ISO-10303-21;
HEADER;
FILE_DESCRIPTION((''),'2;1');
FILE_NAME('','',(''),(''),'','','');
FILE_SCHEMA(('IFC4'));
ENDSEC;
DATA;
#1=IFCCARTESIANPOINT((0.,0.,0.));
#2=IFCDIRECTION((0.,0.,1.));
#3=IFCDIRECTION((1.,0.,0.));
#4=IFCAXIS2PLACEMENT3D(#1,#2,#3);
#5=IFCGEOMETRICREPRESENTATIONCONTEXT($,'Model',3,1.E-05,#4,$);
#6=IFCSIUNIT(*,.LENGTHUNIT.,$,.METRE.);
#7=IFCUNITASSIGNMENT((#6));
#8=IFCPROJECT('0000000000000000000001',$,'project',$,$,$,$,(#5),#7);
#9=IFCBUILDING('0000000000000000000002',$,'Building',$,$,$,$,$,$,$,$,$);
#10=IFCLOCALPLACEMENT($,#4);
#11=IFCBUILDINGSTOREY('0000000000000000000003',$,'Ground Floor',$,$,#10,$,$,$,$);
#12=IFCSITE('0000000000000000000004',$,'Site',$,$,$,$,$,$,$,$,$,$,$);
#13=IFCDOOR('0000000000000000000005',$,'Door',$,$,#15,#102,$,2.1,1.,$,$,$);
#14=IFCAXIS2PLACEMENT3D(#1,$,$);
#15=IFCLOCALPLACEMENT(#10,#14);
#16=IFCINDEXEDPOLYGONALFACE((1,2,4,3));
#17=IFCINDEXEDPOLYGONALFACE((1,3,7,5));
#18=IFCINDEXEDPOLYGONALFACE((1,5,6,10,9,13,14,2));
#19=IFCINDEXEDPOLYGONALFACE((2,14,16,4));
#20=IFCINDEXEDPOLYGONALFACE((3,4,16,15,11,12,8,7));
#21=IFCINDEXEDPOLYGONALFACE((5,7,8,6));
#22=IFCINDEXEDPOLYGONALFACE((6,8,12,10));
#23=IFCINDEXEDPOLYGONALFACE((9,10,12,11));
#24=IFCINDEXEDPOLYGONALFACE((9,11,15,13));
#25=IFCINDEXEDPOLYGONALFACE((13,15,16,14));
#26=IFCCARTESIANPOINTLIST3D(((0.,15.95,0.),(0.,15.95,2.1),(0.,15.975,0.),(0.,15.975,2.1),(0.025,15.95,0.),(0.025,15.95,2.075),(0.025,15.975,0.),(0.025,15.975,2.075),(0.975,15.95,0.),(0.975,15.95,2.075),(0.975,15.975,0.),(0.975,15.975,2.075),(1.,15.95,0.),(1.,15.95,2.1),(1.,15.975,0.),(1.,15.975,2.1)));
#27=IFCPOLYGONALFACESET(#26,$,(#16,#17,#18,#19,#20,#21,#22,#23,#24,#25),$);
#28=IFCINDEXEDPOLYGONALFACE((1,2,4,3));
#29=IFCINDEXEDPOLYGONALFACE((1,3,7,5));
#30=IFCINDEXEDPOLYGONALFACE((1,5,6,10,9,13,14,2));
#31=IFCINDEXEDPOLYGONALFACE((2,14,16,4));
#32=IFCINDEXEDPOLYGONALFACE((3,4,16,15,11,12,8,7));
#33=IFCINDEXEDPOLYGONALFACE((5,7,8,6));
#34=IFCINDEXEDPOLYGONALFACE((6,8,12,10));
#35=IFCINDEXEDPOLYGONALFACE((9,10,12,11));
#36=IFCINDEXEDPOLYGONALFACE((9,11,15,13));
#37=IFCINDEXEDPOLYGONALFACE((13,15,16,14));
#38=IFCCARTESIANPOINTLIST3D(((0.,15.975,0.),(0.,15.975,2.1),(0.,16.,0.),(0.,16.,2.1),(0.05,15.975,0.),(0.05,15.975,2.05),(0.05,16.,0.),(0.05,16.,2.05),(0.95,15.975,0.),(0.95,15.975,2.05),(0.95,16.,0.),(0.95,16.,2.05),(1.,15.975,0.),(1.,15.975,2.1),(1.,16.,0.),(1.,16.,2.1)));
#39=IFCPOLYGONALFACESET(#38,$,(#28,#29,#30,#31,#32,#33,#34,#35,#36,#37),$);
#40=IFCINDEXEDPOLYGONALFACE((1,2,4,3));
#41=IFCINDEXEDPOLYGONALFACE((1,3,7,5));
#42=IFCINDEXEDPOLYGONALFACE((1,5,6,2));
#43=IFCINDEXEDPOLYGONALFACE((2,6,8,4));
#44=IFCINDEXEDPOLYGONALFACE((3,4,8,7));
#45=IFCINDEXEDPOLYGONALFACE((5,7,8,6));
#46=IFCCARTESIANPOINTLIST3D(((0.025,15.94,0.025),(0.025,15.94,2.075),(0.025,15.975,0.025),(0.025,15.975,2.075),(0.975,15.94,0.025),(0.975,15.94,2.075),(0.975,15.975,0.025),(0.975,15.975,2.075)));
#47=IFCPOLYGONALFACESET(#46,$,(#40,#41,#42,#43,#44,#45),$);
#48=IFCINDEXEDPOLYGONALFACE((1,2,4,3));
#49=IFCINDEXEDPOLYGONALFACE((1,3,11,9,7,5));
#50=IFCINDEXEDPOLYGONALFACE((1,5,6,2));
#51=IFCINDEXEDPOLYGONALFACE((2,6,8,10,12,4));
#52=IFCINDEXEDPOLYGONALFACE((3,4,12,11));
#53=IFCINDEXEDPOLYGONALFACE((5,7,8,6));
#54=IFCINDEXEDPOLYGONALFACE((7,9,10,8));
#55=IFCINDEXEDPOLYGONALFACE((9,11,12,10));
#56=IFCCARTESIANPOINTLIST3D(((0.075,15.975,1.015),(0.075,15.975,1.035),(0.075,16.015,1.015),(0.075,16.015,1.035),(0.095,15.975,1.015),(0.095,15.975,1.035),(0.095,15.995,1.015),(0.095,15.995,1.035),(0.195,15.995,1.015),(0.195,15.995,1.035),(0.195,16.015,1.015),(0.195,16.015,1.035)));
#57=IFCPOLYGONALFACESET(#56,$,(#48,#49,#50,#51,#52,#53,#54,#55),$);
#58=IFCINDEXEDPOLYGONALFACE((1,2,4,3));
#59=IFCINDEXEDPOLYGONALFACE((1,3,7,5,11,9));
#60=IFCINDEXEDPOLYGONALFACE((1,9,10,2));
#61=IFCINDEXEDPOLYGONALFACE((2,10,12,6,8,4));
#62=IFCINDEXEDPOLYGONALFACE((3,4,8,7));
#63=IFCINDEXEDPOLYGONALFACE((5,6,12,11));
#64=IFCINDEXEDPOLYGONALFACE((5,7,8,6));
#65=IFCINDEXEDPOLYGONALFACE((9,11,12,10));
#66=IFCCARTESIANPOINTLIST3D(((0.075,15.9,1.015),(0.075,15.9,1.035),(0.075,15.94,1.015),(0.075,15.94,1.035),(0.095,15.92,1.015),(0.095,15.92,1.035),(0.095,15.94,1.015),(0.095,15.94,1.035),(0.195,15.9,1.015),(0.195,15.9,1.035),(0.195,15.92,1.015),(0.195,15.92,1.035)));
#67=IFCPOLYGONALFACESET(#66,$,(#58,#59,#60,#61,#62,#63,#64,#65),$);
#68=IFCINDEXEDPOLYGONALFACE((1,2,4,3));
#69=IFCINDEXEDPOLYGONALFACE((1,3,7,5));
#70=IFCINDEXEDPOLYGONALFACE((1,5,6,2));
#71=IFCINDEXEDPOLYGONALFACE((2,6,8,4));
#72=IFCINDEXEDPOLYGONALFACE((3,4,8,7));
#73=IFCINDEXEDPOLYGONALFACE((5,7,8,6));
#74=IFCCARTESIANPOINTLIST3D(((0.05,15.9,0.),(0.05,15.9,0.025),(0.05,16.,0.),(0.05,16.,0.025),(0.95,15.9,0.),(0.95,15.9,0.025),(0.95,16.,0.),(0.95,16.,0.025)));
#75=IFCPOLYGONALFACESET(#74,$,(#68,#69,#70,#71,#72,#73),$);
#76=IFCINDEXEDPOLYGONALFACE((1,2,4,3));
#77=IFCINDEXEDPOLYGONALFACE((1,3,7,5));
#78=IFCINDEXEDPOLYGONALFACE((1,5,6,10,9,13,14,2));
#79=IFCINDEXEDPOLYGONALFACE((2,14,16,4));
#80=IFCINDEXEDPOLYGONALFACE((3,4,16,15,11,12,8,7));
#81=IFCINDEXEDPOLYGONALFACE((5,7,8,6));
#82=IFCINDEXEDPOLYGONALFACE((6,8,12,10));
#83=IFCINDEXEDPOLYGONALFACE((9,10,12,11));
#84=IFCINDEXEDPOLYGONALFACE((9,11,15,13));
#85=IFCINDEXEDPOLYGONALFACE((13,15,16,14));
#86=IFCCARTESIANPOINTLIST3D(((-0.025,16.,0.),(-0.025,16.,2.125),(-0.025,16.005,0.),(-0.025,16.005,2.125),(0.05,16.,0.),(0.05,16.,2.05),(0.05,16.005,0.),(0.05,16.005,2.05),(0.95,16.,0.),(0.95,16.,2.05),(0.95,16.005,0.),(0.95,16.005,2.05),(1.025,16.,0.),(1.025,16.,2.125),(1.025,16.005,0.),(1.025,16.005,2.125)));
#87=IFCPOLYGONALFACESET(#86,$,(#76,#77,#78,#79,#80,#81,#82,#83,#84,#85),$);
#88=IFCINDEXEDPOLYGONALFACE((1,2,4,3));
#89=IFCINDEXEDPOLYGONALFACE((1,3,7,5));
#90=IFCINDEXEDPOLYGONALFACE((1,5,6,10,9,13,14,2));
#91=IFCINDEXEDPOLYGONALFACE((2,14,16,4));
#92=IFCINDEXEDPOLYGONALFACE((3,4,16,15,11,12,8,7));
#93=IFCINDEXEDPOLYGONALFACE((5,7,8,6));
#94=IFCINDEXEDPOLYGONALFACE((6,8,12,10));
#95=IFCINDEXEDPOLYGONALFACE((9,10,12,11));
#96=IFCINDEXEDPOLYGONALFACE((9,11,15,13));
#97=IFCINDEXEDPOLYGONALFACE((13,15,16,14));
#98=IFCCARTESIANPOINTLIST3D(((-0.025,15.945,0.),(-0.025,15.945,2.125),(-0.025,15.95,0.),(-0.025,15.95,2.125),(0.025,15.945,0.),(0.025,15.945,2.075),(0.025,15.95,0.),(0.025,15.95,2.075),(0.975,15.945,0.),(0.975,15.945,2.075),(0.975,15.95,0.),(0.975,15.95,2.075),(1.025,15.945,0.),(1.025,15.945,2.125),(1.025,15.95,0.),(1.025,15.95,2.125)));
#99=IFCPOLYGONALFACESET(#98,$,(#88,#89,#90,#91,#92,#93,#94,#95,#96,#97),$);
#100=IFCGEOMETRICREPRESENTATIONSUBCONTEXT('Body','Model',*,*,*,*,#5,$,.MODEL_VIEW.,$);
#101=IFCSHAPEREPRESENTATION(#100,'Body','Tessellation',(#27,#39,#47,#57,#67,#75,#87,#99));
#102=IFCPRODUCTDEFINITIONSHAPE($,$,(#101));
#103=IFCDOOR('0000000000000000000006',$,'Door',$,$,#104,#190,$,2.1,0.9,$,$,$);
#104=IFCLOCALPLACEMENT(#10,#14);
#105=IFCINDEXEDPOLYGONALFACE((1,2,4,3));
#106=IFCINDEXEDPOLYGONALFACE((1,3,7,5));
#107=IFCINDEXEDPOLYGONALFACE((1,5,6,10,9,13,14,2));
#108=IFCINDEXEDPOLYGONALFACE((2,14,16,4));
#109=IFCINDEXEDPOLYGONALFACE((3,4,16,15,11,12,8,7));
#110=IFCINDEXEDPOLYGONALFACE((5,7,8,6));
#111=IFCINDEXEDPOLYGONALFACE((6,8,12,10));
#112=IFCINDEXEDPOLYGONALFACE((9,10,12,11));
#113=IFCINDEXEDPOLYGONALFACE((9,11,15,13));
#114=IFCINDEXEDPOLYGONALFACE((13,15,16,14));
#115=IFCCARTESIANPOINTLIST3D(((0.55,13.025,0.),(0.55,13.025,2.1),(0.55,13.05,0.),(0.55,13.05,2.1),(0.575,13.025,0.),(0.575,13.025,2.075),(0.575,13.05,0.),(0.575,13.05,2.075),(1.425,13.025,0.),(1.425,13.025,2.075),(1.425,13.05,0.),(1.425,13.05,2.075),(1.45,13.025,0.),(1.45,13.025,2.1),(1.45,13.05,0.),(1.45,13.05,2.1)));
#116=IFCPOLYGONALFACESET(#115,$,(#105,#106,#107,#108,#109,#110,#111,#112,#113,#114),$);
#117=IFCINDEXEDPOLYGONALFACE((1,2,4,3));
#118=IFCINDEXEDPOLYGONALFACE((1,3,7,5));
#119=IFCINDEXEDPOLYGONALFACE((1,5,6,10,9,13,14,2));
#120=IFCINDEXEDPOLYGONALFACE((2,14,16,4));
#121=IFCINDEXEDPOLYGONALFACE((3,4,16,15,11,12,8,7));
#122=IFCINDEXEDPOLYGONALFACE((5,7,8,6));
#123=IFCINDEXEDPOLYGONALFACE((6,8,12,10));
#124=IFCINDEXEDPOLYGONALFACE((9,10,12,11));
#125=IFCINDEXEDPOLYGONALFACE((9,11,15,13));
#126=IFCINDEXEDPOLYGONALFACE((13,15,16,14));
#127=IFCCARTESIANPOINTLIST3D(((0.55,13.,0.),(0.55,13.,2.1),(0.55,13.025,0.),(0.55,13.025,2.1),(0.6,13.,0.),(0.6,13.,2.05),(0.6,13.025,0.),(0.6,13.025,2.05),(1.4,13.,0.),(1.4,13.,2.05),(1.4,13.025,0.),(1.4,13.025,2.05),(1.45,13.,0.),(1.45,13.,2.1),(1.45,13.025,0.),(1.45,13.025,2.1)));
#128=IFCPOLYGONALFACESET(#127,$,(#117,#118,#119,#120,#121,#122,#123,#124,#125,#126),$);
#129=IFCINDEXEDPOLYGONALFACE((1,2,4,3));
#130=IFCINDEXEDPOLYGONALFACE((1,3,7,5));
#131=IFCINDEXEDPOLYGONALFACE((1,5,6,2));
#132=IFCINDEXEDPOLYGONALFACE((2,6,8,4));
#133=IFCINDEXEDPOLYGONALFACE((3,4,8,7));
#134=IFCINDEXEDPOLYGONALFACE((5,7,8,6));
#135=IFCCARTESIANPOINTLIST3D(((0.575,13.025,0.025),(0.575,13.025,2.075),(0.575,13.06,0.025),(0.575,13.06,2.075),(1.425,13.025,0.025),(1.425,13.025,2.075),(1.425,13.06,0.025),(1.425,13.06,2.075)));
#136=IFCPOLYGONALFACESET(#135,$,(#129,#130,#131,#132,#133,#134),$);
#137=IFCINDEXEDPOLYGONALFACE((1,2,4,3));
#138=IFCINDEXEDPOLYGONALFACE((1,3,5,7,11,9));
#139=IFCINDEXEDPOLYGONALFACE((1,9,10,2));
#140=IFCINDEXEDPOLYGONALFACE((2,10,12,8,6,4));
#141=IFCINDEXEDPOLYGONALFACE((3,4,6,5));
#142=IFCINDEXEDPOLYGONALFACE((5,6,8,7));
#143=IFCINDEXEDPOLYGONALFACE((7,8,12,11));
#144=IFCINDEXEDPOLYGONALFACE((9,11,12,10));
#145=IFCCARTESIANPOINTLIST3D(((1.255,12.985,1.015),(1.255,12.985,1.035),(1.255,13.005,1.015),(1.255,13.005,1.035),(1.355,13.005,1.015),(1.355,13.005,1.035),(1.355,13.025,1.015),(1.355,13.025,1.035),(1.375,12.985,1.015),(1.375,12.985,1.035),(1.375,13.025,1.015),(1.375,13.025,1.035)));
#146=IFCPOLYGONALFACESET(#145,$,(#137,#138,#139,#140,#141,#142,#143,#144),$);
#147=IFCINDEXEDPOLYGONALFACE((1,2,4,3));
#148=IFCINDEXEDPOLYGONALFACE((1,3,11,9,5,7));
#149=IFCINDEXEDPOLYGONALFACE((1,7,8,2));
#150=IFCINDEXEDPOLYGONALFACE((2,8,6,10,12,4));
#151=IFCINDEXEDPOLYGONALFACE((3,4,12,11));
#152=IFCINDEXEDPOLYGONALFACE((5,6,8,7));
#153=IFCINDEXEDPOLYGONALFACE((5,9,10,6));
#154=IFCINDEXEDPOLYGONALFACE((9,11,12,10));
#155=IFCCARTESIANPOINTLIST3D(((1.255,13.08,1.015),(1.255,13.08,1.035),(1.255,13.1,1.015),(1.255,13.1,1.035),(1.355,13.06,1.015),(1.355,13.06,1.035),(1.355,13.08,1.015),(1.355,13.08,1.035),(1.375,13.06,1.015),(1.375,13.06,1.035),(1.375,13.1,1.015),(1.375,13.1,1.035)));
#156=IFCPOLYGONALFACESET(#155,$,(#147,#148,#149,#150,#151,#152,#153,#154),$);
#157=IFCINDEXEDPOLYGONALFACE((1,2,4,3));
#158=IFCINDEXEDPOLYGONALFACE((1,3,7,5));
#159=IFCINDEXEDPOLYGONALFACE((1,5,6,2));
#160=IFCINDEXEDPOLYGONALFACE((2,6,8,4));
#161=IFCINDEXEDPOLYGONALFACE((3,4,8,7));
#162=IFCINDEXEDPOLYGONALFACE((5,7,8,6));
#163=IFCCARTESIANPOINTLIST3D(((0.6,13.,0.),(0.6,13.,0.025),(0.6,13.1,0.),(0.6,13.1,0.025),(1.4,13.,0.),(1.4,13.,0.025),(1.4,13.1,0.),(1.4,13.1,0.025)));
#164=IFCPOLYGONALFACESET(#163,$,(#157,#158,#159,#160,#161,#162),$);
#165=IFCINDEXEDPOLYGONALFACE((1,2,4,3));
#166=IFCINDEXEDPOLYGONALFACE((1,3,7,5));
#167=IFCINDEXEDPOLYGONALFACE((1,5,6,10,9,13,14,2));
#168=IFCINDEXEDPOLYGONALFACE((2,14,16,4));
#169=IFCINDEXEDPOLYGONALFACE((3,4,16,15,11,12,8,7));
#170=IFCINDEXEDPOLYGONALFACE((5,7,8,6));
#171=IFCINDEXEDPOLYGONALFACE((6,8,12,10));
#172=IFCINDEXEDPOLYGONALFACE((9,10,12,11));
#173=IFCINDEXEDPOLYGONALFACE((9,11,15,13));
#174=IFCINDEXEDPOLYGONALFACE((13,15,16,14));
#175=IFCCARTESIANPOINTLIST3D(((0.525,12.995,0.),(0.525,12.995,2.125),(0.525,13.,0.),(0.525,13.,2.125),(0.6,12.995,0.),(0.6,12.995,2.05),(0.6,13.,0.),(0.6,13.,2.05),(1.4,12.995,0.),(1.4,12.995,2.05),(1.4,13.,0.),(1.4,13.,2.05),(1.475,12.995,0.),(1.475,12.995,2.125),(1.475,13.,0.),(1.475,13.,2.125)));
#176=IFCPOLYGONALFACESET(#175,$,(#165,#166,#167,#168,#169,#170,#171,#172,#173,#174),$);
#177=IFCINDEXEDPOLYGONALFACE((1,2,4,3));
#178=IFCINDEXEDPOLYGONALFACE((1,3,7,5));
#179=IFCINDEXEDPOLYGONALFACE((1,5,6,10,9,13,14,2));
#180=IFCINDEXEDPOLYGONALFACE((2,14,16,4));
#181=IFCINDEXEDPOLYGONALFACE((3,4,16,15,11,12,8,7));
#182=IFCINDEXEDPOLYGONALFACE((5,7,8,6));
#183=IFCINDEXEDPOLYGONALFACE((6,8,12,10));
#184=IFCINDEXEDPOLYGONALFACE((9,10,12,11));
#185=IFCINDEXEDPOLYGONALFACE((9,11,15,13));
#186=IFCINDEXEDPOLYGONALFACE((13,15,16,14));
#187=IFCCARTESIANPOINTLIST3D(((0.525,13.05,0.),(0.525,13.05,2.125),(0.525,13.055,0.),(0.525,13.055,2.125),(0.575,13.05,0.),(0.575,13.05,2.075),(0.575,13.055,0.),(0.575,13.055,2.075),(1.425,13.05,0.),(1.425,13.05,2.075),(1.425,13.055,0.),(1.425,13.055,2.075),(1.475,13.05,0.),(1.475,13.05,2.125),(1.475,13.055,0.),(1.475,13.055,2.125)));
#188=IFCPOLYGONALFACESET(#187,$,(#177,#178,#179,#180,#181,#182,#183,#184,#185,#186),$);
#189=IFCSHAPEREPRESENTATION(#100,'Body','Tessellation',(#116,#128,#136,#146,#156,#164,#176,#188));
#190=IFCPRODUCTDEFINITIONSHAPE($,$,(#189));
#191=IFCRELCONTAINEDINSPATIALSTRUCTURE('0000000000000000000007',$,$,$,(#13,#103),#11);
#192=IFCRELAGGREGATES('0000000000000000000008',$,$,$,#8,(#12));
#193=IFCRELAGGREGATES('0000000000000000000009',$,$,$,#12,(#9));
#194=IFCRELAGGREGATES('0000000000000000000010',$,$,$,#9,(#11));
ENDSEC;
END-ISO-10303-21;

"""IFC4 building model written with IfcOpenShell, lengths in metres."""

from ifc_helpers import new_model, si_unit, frame, origin_with_axes, place, context, subcontext, project, spatial, line, indexed_curve, outline, extrude, element, save


model = new_model("IFC4")

# Units and contexts
model_context = context("Model", 3, precision=1e-05, world=origin_with_axes())
body_context = subcontext(model_context, "Body", "Model", "MODEL_VIEW")
ifc_project = project(units=[si_unit("LENGTHUNIT", "METRE")], contexts=[model_context])

# Site, building, storey
site = spatial("IfcSite", under=ifc_project, Name="Site")
building = spatial("IfcBuilding", under=site, Name="Building")
storey_placement = place(None, origin_with_axes())
storey = spatial("IfcBuildingStorey", under=building, at=storey_placement, Name="Ground Floor")

# Doors
door_1_placement = place(storey_placement, frame((1.0, 16.0, 0.0), z_axis=(0.0, 0.0, 1.0), x_axis=(-1.0, 0.0, 0.0)))
element("IfcDoor", 1, at=door_1_placement, inside=storey, Name="Door", OverallHeight=2.1, OverallWidth=1.0, context=body_context, shape_type="SweptSolid", body=[
    extrude(outline(indexed_curve([(0.0, 0.0), (0.0, 2.1), (1.0, 2.1), (1.0, 0.0), (0.975, 0.0), (0.975, 2.075), (0.025, 2.075), (0.025, 0.0)], segments=[line(1, 2, 3, 4, 5, 6, 7, 8, 1)])), frame((0.0, 0.025, 0.0), z_axis=(0.0, -1.0, 0.0), x_axis=(1.0, 0.0, 0.0)), (0.0, 0.0, -1.0), 0.025),
    extrude(outline(indexed_curve([(0.0, 0.0), (0.0, 2.1), (1.0, 2.1), (1.0, 0.0), (0.95, 0.0), (0.95, 2.05), (0.05, 2.05), (0.05, 0.0)], segments=[line(1, 2, 3, 4, 5, 6, 7, 8, 1)])), frame((0.0, 0.0, 0.0), z_axis=(0.0, -1.0, 0.0), x_axis=(1.0, 0.0, 0.0)), (0.0, 0.0, -1.0), 0.025),
    extrude(outline(indexed_curve([(0.0, 0.0), (0.95, 0.0), (0.95, 0.035), (0.0, 0.035)], segments=[line(1, 2, 3, 4, 1)])), frame((0.025, 0.025, 0.025), z_axis=(0.0, 0.0, 1.0), x_axis=(1.0, 0.0, 0.0)), (0.0, 0.0, 1.0), 2.05),
    extrude(outline(indexed_curve([(0.0, 0.0), (0.0, -0.04), (-0.12, -0.04), (-0.12, -0.02), (-0.02, -0.02), (-0.02, 0.0)], segments=[line(1, 2, 3, 4, 5, 6, 1)])), frame((0.925, 0.025, 1.015), z_axis=(0.0, 0.0, 1.0), x_axis=(1.0, 0.0, 0.0)), (0.0, 0.0, 1.0), 0.02),
    extrude(outline(indexed_curve([(0.0, 0.0), (0.0, 0.04), (-0.12, 0.04), (-0.12, 0.02), (-0.02, 0.02), (-0.02, 0.0)], segments=[line(1, 2, 3, 4, 5, 6, 1)])), frame((0.925, 0.06, 1.015), z_axis=(0.0, 0.0, 1.0), x_axis=(1.0, 0.0, 0.0)), (0.0, 0.0, 1.0), 0.02),
    extrude(outline(indexed_curve([(0.0, 0.0), (0.9, 0.0), (0.9, 0.1), (0.0, 0.1)], segments=[line(1, 2, 3, 4, 1)])), frame((0.05, 0.0, 0.0), z_axis=(0.0, 0.0, 1.0), x_axis=(1.0, 0.0, 0.0)), (0.0, 0.0, 1.0), 0.025),
    extrude(outline(indexed_curve([(0.0, 0.0), (0.0, 2.125), (1.05, 2.125), (1.05, 0.0), (0.975, 0.0), (0.975, 2.05), (0.075, 2.05), (0.075, 0.0)], segments=[line(1, 2, 3, 4, 5, 6, 7, 8, 1)])), frame((-0.025, -0.005, 0.0), z_axis=(0.0, -1.0, 0.0), x_axis=(1.0, 0.0, 0.0)), (0.0, 0.0, -1.0), 0.005),
    extrude(outline(indexed_curve([(0.0, 0.0), (0.0, 2.125), (1.05, 2.125), (1.05, 0.0), (1.0, 0.0), (1.0, 2.075), (0.05, 2.075), (0.05, 0.0)], segments=[line(1, 2, 3, 4, 5, 6, 7, 8, 1)])), frame((-0.025, 0.05, 0.0), z_axis=(0.0, -1.0, 0.0), x_axis=(1.0, 0.0, 0.0)), (0.0, 0.0, -1.0), 0.005),
])
door_2_placement = place(storey_placement, frame((0.55, 13.0, 0.0), z_axis=(0.0, 0.0, 1.0), x_axis=(1.0, 0.0, 0.0)))
element("IfcDoor", 2, at=door_2_placement, inside=storey, Name="Door", OverallHeight=2.1, OverallWidth=0.9, context=body_context, shape_type="SweptSolid", body=[
    extrude(outline(indexed_curve([(0.0, 0.0), (0.0, 2.1), (0.9, 2.1), (0.9, 0.0), (0.875, 0.0), (0.875, 2.075), (0.025, 2.075), (0.025, 0.0)], segments=[line(1, 2, 3, 4, 5, 6, 7, 8, 1)])), frame((0.0, 0.025, 0.0), z_axis=(0.0, -1.0, 0.0), x_axis=(1.0, 0.0, 0.0)), (0.0, 0.0, -1.0), 0.025),
    extrude(outline(indexed_curve([(0.0, 0.0), (0.0, 2.1), (0.9, 2.1), (0.9, 0.0), (0.85, 0.0), (0.85, 2.05), (0.05, 2.05), (0.05, 0.0)], segments=[line(1, 2, 3, 4, 5, 6, 7, 8, 1)])), frame((0.0, 0.0, 0.0), z_axis=(0.0, -1.0, 0.0), x_axis=(1.0, 0.0, 0.0)), (0.0, 0.0, -1.0), 0.025),
    extrude(outline(indexed_curve([(0.0, 0.0), (0.85, 0.0), (0.85, 0.035), (0.0, 0.035)], segments=[line(1, 2, 3, 4, 1)])), frame((0.025, 0.025, 0.025), z_axis=(0.0, 0.0, 1.0), x_axis=(1.0, 0.0, 0.0)), (0.0, 0.0, 1.0), 2.05),
    extrude(outline(indexed_curve([(0.0, 0.0), (0.0, -0.04), (-0.12, -0.04), (-0.12, -0.02), (-0.02, -0.02), (-0.02, 0.0)], segments=[line(1, 2, 3, 4, 5, 6, 1)])), frame((0.825, 0.025, 1.015), z_axis=(0.0, 0.0, 1.0), x_axis=(1.0, 0.0, 0.0)), (0.0, 0.0, 1.0), 0.02),
    extrude(outline(indexed_curve([(0.0, 0.0), (0.0, 0.04), (-0.12, 0.04), (-0.12, 0.02), (-0.02, 0.02), (-0.02, 0.0)], segments=[line(1, 2, 3, 4, 5, 6, 1)])), frame((0.825, 0.06, 1.015), z_axis=(0.0, 0.0, 1.0), x_axis=(1.0, 0.0, 0.0)), (0.0, 0.0, 1.0), 0.02),
    extrude(outline(indexed_curve([(0.0, 0.0), (0.8, 0.0), (0.8, 0.1), (0.0, 0.1)], segments=[line(1, 2, 3, 4, 1)])), frame((0.05, 0.0, 0.0), z_axis=(0.0, 0.0, 1.0), x_axis=(1.0, 0.0, 0.0)), (0.0, 0.0, 1.0), 0.025),
    extrude(outline(indexed_curve([(0.0, 0.0), (0.0, 2.125), (0.95, 2.125), (0.95, 0.0), (0.875, 0.0), (0.875, 2.05), (0.075, 2.05), (0.075, 0.0)], segments=[line(1, 2, 3, 4, 5, 6, 7, 8, 1)])), frame((-0.025, -0.005, 0.0), z_axis=(0.0, -1.0, 0.0), x_axis=(1.0, 0.0, 0.0)), (0.0, 0.0, -1.0), 0.005),
    extrude(outline(indexed_curve([(0.0, 0.0), (0.0, 2.125), (0.95, 2.125), (0.95, 0.0), (0.9, 0.0), (0.9, 2.075), (0.05, 2.075), (0.05, 0.0)], segments=[line(1, 2, 3, 4, 5, 6, 7, 8, 1)])), frame((-0.025, 0.05, 0.0), z_axis=(0.0, -1.0, 0.0), x_axis=(1.0, 0.0, 0.0)), (0.0, 0.0, -1.0), 0.005),
])

save(model, "model.ifc")
